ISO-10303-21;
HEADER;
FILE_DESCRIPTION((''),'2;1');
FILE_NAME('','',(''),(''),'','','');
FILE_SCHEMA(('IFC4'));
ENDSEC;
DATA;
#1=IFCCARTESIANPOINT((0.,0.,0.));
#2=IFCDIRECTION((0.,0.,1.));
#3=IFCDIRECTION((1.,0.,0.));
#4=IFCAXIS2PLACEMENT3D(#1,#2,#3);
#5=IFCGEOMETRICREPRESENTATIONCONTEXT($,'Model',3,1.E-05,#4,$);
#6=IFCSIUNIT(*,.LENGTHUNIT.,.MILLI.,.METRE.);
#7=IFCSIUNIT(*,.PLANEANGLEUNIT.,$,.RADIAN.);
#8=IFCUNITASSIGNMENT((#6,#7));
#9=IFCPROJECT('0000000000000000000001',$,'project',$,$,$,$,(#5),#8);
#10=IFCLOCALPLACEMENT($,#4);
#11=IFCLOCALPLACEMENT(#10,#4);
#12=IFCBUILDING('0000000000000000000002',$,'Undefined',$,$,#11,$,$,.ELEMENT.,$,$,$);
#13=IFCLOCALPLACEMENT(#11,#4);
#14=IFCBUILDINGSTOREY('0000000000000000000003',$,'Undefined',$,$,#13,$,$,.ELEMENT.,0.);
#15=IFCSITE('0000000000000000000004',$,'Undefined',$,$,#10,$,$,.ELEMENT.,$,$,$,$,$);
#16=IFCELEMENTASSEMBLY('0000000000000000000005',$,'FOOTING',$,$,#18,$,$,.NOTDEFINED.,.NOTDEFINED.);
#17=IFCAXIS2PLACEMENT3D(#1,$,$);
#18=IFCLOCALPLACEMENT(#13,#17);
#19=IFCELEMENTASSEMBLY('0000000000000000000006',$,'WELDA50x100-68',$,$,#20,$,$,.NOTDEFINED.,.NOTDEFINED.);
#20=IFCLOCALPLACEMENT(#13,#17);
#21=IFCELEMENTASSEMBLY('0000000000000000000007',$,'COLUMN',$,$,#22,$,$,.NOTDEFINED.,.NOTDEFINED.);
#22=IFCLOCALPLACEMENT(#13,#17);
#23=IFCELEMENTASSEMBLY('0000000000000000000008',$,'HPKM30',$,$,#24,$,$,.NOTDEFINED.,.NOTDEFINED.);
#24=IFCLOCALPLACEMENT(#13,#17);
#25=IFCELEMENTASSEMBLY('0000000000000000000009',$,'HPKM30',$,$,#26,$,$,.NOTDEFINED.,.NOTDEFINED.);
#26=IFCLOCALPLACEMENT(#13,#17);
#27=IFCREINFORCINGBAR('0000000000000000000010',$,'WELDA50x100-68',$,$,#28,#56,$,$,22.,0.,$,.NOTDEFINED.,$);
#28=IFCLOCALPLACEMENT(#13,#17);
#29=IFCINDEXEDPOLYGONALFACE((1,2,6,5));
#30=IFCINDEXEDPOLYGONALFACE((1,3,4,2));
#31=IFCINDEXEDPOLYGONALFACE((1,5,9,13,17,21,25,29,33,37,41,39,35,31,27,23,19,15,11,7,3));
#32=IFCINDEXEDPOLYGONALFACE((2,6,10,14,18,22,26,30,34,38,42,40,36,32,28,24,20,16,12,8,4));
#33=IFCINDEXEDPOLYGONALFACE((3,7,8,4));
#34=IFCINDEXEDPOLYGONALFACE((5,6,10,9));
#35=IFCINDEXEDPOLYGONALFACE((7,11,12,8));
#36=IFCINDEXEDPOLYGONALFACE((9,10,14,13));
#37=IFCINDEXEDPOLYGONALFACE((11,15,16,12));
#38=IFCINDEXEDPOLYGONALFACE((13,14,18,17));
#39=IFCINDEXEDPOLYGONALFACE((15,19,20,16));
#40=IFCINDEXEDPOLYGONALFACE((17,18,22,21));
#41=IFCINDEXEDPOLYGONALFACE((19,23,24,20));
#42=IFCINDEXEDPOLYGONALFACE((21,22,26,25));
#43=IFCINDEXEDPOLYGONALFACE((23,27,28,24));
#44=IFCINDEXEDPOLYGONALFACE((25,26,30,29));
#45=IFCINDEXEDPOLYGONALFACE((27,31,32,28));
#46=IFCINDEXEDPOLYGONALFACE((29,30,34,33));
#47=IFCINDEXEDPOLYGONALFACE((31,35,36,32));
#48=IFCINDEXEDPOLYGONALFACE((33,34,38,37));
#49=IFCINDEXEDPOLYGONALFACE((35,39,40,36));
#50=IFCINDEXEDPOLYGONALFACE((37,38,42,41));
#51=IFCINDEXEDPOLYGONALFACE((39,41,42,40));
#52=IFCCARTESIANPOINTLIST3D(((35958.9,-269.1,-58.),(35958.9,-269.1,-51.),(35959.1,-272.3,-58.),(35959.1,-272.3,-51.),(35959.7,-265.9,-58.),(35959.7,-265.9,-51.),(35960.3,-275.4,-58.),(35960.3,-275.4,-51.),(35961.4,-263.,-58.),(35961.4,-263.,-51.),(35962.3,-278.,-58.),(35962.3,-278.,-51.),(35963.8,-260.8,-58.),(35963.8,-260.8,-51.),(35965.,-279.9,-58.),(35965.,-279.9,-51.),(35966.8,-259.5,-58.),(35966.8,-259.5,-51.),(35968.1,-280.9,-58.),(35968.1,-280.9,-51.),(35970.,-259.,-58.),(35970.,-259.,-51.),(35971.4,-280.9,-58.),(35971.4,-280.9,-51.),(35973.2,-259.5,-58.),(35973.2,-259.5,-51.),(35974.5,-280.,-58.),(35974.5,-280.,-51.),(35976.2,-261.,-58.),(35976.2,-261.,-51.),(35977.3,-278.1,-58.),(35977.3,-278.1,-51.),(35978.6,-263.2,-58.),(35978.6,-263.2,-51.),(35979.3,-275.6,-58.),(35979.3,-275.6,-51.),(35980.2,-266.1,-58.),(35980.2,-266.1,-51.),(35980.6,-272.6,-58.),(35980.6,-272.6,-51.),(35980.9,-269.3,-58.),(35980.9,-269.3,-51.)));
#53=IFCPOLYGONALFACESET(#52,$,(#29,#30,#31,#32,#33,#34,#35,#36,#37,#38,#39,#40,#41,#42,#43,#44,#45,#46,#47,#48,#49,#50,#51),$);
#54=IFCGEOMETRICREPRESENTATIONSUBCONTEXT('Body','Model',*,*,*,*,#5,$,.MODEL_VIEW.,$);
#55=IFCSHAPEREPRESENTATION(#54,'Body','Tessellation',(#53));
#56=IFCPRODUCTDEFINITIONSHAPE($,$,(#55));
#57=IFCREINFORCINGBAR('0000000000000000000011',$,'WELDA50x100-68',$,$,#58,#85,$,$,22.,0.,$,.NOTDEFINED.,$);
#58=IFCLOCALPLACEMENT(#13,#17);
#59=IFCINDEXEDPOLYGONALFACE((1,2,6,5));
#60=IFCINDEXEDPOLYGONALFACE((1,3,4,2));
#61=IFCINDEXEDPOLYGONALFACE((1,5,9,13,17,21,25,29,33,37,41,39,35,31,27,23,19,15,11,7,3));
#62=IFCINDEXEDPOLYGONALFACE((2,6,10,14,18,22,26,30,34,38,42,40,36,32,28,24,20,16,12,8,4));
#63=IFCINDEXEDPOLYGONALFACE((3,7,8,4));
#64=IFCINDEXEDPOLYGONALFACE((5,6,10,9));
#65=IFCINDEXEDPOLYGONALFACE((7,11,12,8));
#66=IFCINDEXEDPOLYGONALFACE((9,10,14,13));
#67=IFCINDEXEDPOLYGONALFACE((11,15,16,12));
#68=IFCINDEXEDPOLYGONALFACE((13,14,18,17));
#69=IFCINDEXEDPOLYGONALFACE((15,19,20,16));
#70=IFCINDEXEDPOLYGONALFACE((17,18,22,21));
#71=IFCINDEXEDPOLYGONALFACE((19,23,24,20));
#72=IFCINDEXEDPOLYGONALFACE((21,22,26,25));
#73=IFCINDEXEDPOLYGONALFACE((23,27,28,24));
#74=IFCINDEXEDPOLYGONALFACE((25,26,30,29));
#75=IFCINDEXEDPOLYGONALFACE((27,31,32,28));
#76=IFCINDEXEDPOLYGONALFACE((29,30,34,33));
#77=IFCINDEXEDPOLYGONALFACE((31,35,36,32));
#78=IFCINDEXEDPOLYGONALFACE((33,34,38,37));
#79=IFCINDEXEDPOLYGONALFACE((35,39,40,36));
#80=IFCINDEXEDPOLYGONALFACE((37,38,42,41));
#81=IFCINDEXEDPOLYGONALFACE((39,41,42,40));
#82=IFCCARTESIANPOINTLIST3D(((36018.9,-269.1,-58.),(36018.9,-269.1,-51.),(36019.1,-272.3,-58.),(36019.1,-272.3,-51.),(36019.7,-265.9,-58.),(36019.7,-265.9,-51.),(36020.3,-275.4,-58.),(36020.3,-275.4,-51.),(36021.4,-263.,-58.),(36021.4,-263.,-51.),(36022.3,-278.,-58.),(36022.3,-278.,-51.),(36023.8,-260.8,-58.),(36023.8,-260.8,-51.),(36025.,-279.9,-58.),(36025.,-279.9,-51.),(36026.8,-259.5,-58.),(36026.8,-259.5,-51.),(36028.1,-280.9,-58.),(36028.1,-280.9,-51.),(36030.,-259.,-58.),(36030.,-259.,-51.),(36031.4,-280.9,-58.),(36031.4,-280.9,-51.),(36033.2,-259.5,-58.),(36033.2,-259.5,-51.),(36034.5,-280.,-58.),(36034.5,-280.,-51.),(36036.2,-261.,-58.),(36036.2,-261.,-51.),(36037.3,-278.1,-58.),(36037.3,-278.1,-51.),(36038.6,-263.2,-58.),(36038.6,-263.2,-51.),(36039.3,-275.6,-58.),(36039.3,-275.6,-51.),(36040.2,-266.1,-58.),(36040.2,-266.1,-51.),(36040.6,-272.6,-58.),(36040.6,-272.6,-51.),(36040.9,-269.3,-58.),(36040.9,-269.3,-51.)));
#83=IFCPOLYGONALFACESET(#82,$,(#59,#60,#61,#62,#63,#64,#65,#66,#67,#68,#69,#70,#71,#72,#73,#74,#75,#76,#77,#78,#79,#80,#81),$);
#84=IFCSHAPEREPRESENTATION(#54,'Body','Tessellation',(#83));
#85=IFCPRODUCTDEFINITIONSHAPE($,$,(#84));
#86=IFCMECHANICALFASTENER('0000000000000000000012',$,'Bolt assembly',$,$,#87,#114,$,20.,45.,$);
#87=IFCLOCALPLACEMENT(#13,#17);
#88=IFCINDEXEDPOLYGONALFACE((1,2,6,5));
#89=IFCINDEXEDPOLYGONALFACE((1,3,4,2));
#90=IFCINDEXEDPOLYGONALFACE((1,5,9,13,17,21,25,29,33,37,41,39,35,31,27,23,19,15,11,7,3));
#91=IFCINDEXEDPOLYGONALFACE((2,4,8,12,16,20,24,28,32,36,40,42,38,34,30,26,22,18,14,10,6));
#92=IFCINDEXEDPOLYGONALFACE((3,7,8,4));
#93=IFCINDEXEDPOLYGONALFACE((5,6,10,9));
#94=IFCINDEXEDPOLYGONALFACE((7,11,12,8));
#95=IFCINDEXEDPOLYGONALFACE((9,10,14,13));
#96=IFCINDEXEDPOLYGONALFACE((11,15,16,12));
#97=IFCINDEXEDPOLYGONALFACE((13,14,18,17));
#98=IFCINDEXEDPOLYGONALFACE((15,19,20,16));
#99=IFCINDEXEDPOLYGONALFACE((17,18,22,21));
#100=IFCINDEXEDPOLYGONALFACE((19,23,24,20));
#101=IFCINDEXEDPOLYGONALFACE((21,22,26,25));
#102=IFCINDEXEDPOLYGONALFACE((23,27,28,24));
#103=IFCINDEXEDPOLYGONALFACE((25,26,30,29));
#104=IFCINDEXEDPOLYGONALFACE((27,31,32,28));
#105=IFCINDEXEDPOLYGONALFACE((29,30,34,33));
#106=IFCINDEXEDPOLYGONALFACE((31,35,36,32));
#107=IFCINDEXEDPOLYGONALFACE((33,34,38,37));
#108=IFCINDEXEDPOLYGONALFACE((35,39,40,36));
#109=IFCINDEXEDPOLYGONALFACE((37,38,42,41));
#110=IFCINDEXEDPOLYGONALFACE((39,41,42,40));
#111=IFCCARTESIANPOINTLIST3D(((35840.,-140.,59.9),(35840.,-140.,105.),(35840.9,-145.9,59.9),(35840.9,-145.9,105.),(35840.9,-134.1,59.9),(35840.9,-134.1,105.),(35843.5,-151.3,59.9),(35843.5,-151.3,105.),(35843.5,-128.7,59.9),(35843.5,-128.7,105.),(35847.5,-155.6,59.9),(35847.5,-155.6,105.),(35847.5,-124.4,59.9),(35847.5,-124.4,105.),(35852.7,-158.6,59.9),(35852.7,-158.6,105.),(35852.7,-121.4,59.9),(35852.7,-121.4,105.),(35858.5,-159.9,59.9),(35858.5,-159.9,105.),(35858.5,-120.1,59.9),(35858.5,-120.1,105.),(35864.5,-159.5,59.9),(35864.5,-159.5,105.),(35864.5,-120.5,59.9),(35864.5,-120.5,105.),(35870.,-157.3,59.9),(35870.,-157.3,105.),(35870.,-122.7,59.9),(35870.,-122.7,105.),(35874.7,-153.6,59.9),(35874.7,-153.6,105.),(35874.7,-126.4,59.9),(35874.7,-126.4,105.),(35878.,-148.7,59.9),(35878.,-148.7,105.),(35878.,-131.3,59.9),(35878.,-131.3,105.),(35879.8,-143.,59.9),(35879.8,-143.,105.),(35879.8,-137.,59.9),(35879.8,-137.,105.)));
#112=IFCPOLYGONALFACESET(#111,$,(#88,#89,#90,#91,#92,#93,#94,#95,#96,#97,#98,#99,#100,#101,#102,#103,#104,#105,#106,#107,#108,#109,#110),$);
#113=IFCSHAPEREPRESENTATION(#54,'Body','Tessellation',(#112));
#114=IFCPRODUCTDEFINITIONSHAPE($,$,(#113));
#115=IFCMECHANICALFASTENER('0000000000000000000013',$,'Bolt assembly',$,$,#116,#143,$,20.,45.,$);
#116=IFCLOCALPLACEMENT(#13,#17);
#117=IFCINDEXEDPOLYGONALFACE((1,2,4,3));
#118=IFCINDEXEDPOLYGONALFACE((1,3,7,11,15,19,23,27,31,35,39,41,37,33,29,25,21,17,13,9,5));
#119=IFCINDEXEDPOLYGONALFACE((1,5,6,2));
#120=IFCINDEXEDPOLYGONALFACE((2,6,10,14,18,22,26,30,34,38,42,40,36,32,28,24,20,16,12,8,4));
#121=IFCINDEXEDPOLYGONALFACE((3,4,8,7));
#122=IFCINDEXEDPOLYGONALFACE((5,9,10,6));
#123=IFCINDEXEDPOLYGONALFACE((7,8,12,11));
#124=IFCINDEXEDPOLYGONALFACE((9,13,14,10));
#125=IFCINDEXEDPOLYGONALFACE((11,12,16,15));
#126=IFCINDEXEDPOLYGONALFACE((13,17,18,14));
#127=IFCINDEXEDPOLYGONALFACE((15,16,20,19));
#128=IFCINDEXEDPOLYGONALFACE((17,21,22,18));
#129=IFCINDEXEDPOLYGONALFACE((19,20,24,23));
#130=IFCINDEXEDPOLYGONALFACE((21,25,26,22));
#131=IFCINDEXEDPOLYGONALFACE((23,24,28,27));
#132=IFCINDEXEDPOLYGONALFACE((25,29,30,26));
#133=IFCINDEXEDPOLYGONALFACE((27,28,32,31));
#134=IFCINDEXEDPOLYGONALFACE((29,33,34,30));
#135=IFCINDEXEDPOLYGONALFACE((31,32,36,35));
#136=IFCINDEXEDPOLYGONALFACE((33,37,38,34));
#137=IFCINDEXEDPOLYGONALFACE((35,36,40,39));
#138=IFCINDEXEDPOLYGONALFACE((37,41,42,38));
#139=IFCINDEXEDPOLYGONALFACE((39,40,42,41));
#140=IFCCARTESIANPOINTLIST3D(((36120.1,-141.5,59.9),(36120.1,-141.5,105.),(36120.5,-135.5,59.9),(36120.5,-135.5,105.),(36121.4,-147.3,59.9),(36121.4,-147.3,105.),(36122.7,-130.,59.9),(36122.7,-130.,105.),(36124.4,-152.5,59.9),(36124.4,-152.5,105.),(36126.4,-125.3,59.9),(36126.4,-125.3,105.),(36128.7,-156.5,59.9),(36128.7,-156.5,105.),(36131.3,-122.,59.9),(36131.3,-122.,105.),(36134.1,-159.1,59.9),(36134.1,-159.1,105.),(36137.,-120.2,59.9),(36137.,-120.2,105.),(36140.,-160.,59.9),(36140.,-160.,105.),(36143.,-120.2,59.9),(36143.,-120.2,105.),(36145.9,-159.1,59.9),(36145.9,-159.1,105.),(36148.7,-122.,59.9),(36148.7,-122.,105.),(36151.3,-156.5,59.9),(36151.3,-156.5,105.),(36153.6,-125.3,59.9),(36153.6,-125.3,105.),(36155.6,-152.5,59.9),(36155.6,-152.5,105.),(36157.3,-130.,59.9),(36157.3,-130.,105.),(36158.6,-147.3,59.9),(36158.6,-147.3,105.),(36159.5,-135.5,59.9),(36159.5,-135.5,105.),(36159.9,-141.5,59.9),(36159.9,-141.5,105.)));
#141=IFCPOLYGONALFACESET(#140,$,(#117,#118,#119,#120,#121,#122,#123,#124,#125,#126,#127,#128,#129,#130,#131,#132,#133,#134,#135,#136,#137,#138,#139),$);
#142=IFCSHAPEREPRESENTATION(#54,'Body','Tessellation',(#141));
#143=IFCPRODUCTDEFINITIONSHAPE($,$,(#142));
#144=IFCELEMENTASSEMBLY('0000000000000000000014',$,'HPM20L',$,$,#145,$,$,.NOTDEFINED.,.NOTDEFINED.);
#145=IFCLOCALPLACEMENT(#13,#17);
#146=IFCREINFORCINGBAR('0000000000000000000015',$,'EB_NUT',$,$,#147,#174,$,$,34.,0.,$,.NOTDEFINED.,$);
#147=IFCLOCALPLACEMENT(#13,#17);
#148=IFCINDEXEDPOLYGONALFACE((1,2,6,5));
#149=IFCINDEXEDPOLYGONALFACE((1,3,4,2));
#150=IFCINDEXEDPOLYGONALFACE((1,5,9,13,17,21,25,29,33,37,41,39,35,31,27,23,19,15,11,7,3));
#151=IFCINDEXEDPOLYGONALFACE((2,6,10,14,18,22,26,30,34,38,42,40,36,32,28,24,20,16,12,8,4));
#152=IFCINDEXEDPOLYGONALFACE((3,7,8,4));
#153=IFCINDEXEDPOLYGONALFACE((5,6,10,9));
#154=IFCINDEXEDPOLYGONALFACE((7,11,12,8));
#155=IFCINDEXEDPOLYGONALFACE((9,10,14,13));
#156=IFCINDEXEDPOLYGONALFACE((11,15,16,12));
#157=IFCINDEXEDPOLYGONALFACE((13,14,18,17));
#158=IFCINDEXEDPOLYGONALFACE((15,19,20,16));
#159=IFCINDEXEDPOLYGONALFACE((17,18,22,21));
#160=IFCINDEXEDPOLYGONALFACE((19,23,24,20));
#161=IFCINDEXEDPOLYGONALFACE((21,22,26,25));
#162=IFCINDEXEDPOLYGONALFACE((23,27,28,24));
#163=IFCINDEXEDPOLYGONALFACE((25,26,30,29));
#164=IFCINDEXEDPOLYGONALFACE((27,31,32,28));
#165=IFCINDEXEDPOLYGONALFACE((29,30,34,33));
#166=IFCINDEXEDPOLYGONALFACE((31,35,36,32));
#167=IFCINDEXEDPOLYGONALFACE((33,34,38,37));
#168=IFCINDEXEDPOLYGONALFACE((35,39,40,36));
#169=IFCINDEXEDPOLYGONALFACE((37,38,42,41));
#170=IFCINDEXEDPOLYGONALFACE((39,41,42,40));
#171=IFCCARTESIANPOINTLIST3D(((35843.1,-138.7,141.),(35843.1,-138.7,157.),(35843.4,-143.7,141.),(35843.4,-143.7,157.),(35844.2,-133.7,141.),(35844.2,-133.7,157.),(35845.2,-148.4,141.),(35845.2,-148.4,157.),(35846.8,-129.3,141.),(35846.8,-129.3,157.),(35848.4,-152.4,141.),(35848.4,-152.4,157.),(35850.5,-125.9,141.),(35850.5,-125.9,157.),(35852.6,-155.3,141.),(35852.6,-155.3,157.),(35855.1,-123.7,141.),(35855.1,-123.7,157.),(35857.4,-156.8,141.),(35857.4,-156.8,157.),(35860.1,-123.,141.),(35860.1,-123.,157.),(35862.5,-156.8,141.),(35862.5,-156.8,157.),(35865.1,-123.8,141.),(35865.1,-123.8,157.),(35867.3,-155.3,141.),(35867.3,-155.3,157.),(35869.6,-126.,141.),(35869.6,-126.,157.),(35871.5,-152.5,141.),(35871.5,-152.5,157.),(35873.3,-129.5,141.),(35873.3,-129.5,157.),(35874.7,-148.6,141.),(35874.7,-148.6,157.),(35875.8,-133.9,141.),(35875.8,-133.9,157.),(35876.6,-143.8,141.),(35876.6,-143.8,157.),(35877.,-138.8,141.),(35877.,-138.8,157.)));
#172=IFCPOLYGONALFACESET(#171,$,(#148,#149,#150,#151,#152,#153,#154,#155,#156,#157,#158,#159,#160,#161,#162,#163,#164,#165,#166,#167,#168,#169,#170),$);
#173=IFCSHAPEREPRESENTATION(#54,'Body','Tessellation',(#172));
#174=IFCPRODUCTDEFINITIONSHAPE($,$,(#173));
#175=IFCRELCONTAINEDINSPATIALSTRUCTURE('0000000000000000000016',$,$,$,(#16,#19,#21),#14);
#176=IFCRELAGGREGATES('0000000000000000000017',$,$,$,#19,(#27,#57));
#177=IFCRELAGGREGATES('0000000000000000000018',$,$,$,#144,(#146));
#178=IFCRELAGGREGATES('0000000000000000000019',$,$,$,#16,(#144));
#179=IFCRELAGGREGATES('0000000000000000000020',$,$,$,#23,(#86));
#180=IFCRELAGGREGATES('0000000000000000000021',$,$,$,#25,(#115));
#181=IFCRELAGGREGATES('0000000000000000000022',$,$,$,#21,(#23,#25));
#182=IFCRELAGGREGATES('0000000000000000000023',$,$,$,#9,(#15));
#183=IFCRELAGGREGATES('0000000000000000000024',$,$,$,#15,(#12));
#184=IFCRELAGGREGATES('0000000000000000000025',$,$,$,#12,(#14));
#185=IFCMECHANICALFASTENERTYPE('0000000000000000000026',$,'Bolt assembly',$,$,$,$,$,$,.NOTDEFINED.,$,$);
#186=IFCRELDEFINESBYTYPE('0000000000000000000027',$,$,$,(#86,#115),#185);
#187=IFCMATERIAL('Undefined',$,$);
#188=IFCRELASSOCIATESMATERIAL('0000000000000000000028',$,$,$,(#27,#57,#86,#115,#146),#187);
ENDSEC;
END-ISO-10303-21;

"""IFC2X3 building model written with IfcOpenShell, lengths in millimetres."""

from ifc_helpers import new_model, entity, si_unit, frame, origin_with_axes, origin_2d_with_axis, place, context, subcontext, project, spatial, circle, extrude, source, transform, mapped, material, type_object, element, aggregate, save


model = new_model("IFC2X3")

# Units and contexts
model_context = context("Model", 3, precision=1e-05, world=origin_with_axes())
body_context = subcontext(model_context, "Body", "Model", "MODEL_VIEW")
ifc_project = project(units=[si_unit("LENGTHUNIT", "METRE", prefix="MILLI"), si_unit("PLANEANGLEUNIT", "RADIAN")], contexts=[model_context])

# Site, building, storey
site_placement = place(None, origin_with_axes())
site = spatial("IfcSite", under=ifc_project, at=site_placement, Name="Undefined", CompositionType="ELEMENT")
building_placement = place(site_placement, origin_with_axes())
building = spatial("IfcBuilding", under=site, at=building_placement, Name="Undefined", CompositionType="ELEMENT")
storey_placement = place(building_placement, origin_with_axes())
storey = spatial("IfcBuildingStorey", under=building, at=storey_placement, Name="Undefined", CompositionType="ELEMENT", Elevation=0.0)

# Element assembly
assembly_1_placement = place(storey_placement, origin_with_axes())
assembly_1 = element("IfcElementAssembly", 1, at=assembly_1_placement, inside=storey, Name="FOOTING", AssemblyPlace="NOTDEFINED", PredefinedType="NOTDEFINED")

# Element assembly
assembly_2_placement = place(storey_placement, origin_with_axes())
assembly_2 = element("IfcElementAssembly", 2, at=assembly_2_placement, inside=storey, Name="WELDA50x100-68", AssemblyPlace="NOTDEFINED", PredefinedType="NOTDEFINED")

# Element assemblies
assembly_3_placement = place(storey_placement, origin_with_axes())
assembly_3 = element("IfcElementAssembly", 3, at=assembly_3_placement, inside=storey, Name="COLUMN", AssemblyPlace="NOTDEFINED", PredefinedType="NOTDEFINED")
assembly_4_placement = place(assembly_3_placement, origin_with_axes())
assembly_4 = element("IfcElementAssembly", 4, at=assembly_4_placement, Name="HPKM30", AssemblyPlace="NOTDEFINED", PredefinedType="NOTDEFINED")
assembly_5_placement = place(assembly_3_placement, origin_with_axes())
assembly_5 = element("IfcElementAssembly", 5, at=assembly_5_placement, Name="HPKM30", AssemblyPlace="NOTDEFINED", PredefinedType="NOTDEFINED")

# Reinforcing bars
ifc_material_1 = material(Name="Undefined")
shared_shape_1 = source(origin_with_axes(), body_context, "Body", "AdvancedSweptSolid", [
    entity("IfcSweptDiskSolid", entity("IfcTrimmedCurve", entity("IfcLine", entity("IfcCartesianPoint", [0.0, 0.0, 0.0]), entity("IfcVector", entity("IfcDirection", [1.0, 0.0, 0.0]), 1.0)), [entity("IfcParameterValue", 0.0)], [entity("IfcParameterValue", 7.0)], True, "PARAMETER"), 11.0, None, 0.0, 7.0),
])
reinforcing_bar_1_placement = place(assembly_2_placement, frame((35969.9, -270.0, -51.0), z_axis=(0.011111, 0.999938, 0.0), x_axis=(0.0, 0.0, -1.0)))
reinforcing_bar_1 = element("IfcReinforcingBar", 6, at=reinforcing_bar_1_placement, material=ifc_material_1, Name="WELDA50x100-68", BarRole="NOTDEFINED", CrossSectionArea=0.0, NominalDiameter=22.0, context=body_context, shape_type="MappedRepresentation", body=[
    mapped(shared_shape_1, transform((0.0, 0.0, 0.0))),
])
shared_shape_2 = source(origin_with_axes(), body_context, "Body", "AdvancedSweptSolid", [
    entity("IfcSweptDiskSolid", entity("IfcTrimmedCurve", entity("IfcLine", entity("IfcCartesianPoint", [0.0, 0.0, 0.0]), entity("IfcVector", entity("IfcDirection", [1.0, 0.0, 0.0]), 1.0)), [entity("IfcParameterValue", 0.0)], [entity("IfcParameterValue", 7.0)], True, "PARAMETER"), 11.0, None, 0.0, 7.0),
])
reinforcing_bar_2_placement = place(assembly_2_placement, frame((36029.9, -270.0, -51.0), z_axis=(0.011111, 0.999938, 0.0), x_axis=(0.0, 0.0, -1.0)))
reinforcing_bar_2 = element("IfcReinforcingBar", 7, at=reinforcing_bar_2_placement, material=ifc_material_1, Name="WELDA50x100-68", BarRole="NOTDEFINED", CrossSectionArea=0.0, NominalDiameter=22.0, context=body_context, shape_type="MappedRepresentation", body=[
    mapped(shared_shape_2, transform((0.0, 0.0, 0.0))),
])
aggregate(assembly_2, [reinforcing_bar_1, reinforcing_bar_2])

# Mechanical fasteners
mechanical_fastener_type = type_object("IfcMechanicalFastenerType", Name="Bolt assembly")
shared_shape_3 = source(origin_with_axes(), body_context, "Body", "SweptSolid", [
    extrude(circle(Radius=20.0, at=origin_2d_with_axis()), frame((0.0, -45.0, 0.0), z_axis=(0.0, 1.0, 0.0), x_axis=(1.0, 0.0, 0.0)), (0.0, 0.0, 1.0), 45.1),
])
mechanical_fastener_1_placement = place(assembly_4_placement, frame((35860.0, -140.0, 60.0), z_axis=(0.0, -1.0, 0.0), x_axis=(-1.0, 0.0, 0.0)))
mechanical_fastener_1 = element("IfcMechanicalFastener", 8, at=mechanical_fastener_1_placement, type_object=mechanical_fastener_type, material=ifc_material_1, Name="Bolt assembly", NominalDiameter=20.0, NominalLength=45.0, context=body_context, shape_type="MappedRepresentation", body=[
    mapped(shared_shape_3, transform((0.0, 0.0, 0.0))),
])
mechanical_fastener_2_placement = place(assembly_5_placement, frame((36140.0, -140.0, 60.0), z_axis=(1.0, 0.0, 0.0), x_axis=(0.0, -1.0, 0.0)))
mechanical_fastener_2 = element("IfcMechanicalFastener", 9, at=mechanical_fastener_2_placement, type_object=mechanical_fastener_type, material=ifc_material_1, Name="Bolt assembly", NominalDiameter=20.0, NominalLength=45.0, context=body_context, shape_type="MappedRepresentation", body=[
    mapped(shared_shape_3, transform((0.0, 0.0, 0.0))),
])

# Element assembly, reinforcing bar
assembly_6_placement = place(assembly_1_placement, origin_with_axes())
assembly_6 = element("IfcElementAssembly", 10, at=assembly_6_placement, Name="HPM20L", AssemblyPlace="NOTDEFINED", PredefinedType="NOTDEFINED")
shared_shape_4 = source(origin_with_axes(), body_context, "Body", "AdvancedSweptSolid", [
    entity("IfcSweptDiskSolid", entity("IfcTrimmedCurve", entity("IfcLine", entity("IfcCartesianPoint", [0.0, 0.0, 0.0]), entity("IfcVector", entity("IfcDirection", [1.0, 0.0, 0.0]), 1.0)), [entity("IfcParameterValue", 0.0)], [entity("IfcParameterValue", 16.0)], True, "PARAMETER"), 17.0, None, 0.0, 16.0),
])
reinforcing_bar_3_placement = place(assembly_6_placement, frame((35860.0, -140.0, 157.0), z_axis=(0.003904, 0.999992, 0.0), x_axis=(0.0, 0.0, -1.0)))
reinforcing_bar_3 = element("IfcReinforcingBar", 11, at=reinforcing_bar_3_placement, material=ifc_material_1, Name="EB_NUT", BarRole="NOTDEFINED", CrossSectionArea=0.0, NominalDiameter=34.0, context=body_context, shape_type="MappedRepresentation", body=[
    mapped(shared_shape_4, transform((0.0, 0.0, 0.0))),
])
aggregate(assembly_6, [reinforcing_bar_3])

aggregate(assembly_1, [assembly_6])

aggregate(assembly_4, [mechanical_fastener_1])
aggregate(assembly_5, [mechanical_fastener_2])
aggregate(assembly_3, [assembly_4, assembly_5])

save(model, "model.ifc")
